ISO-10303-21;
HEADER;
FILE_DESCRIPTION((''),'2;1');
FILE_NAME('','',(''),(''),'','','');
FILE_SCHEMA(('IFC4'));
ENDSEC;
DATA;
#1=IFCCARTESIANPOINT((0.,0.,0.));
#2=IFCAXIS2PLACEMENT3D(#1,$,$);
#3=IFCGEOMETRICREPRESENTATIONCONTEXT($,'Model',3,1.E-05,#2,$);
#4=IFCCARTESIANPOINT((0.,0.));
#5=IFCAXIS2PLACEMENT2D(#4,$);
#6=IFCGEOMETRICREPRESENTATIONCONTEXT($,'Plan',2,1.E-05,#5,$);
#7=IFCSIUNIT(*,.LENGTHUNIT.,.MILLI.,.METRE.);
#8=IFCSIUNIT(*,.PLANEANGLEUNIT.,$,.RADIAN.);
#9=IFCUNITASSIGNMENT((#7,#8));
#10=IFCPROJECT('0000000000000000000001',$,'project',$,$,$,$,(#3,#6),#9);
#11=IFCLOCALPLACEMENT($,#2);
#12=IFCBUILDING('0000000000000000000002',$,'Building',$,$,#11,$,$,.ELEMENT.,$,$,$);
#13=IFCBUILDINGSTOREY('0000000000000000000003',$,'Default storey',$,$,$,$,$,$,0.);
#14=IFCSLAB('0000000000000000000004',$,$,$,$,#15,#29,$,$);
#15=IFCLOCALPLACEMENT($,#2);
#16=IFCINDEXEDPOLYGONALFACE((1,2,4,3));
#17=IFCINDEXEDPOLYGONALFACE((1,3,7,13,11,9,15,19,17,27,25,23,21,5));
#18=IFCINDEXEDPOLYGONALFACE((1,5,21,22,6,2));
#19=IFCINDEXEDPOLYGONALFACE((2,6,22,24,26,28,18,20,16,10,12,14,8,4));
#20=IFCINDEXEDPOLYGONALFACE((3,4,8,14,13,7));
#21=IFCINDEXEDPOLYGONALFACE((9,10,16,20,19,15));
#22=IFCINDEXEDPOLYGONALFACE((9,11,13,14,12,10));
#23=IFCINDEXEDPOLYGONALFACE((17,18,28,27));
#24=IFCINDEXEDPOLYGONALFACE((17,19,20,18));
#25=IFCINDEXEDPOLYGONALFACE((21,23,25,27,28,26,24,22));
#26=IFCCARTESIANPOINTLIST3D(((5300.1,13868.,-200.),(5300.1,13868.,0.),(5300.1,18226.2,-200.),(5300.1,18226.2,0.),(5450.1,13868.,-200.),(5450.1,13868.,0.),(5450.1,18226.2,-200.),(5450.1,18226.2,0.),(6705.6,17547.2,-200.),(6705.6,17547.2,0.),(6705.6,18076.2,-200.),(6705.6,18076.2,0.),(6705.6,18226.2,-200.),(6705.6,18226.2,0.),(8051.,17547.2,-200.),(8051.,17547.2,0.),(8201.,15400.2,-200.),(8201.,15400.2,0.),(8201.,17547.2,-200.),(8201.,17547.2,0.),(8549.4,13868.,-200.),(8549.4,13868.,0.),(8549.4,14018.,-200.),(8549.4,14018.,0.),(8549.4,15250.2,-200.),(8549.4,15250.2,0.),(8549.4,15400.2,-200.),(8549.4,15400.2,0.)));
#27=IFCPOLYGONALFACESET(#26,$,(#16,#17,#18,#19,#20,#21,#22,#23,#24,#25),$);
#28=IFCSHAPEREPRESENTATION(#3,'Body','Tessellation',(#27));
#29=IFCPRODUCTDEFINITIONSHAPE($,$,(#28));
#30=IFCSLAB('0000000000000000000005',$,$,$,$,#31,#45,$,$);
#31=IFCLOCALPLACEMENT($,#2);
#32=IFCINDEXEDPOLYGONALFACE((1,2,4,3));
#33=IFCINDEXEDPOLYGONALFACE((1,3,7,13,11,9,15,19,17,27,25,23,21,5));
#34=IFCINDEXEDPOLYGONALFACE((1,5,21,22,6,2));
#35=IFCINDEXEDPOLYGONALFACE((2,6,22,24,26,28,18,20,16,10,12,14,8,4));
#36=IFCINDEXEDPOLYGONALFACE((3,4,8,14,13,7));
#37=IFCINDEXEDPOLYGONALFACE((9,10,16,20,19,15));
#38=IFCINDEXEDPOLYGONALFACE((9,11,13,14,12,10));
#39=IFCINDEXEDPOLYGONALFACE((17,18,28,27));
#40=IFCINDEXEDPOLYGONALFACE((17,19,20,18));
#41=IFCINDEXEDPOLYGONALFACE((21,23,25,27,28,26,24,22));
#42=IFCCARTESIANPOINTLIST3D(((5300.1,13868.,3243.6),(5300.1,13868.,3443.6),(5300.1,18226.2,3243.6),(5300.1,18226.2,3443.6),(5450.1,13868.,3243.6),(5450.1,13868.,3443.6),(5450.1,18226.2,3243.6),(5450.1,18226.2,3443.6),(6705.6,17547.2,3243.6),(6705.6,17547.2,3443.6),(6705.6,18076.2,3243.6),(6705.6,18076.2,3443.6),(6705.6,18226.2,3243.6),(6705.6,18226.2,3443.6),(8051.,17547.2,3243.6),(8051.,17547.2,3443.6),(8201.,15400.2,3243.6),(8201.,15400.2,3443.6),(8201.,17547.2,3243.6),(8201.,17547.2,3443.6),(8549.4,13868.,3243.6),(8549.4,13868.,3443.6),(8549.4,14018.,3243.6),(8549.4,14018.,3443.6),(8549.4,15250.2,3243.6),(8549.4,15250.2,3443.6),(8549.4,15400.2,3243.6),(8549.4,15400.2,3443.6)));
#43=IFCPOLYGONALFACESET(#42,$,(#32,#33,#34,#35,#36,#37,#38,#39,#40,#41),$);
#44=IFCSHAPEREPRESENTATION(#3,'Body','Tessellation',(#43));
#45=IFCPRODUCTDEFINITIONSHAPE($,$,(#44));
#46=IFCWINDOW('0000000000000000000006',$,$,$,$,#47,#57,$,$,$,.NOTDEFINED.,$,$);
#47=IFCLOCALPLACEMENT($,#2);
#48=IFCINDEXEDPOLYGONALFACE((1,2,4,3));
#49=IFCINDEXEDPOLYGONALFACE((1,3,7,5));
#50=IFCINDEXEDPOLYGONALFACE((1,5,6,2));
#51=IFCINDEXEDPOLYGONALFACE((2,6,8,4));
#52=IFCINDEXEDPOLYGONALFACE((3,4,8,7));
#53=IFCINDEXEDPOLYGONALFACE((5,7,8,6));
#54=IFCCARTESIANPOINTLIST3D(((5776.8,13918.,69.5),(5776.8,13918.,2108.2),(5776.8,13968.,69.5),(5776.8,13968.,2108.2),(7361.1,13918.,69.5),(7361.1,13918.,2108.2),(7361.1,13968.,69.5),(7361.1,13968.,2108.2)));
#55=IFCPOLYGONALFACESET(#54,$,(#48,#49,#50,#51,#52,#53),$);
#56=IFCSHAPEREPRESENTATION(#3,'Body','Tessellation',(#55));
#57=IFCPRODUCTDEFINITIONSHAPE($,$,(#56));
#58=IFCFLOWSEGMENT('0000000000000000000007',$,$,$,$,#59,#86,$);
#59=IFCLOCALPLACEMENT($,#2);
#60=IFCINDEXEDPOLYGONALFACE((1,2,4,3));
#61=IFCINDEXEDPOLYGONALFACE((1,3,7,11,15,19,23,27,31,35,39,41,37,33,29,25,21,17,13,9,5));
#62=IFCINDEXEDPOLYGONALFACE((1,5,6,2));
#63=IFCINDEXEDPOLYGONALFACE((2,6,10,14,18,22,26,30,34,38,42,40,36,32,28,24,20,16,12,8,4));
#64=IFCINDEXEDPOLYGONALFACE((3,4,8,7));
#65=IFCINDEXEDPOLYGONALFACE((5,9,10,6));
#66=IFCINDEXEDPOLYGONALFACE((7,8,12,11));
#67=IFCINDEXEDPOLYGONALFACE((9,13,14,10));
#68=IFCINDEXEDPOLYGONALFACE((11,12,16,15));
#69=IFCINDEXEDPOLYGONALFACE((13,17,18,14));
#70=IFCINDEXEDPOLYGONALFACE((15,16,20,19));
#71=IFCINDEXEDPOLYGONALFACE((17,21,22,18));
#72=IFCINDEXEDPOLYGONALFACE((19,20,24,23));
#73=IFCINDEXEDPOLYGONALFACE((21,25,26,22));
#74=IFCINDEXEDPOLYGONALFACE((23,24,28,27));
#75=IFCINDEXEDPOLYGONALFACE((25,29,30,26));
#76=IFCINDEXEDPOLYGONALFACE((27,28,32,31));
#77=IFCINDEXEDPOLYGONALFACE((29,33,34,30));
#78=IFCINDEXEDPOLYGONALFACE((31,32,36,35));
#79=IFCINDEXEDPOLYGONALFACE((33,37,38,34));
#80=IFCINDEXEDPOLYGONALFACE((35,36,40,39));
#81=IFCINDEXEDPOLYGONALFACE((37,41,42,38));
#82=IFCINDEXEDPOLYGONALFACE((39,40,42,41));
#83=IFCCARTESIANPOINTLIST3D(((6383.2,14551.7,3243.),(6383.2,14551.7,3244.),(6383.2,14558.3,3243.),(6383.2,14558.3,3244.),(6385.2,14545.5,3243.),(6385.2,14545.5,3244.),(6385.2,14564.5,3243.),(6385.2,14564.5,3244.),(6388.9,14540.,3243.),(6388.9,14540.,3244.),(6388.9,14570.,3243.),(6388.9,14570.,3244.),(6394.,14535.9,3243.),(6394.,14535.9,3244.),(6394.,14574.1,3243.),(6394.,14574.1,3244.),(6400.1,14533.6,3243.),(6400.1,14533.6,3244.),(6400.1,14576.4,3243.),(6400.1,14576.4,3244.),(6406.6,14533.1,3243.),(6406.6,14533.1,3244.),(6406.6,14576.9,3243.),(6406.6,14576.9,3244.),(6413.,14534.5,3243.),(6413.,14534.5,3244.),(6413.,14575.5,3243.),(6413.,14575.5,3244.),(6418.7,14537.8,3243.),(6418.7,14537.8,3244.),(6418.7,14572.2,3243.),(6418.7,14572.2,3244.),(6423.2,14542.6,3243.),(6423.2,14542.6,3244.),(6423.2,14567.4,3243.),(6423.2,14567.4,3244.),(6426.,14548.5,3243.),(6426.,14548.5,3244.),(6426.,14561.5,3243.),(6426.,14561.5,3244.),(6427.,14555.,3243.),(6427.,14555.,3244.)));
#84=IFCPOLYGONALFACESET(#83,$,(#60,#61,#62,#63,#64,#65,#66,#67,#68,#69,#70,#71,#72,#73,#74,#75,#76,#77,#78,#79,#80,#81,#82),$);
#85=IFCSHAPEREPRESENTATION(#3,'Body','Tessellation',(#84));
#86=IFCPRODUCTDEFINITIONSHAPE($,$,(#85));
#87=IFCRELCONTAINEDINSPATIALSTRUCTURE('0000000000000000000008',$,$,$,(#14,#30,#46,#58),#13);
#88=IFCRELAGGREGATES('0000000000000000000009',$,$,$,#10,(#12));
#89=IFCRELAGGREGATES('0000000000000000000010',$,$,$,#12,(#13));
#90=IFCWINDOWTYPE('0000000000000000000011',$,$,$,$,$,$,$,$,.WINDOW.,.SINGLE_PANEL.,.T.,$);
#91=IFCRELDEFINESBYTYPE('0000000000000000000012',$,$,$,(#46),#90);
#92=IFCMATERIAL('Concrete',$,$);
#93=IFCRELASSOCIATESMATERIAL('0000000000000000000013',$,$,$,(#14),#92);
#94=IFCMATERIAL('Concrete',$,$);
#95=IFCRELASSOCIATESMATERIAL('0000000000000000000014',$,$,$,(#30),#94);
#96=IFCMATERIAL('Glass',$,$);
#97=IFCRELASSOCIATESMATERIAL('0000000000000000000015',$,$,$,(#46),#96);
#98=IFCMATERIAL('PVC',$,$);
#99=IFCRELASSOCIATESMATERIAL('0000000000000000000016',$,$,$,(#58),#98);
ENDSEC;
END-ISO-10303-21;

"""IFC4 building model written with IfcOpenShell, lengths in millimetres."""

from ifc_helpers import new_model, si_unit, frame, origin, origin_2d, place, context, project, spatial, polyline, rectangle, circle, outline, extrude, material, type_object, element, save


model = new_model("IFC4")

# Units and contexts
model_context = context("Model", 3, precision=1e-05, world=origin())
plan_context = context("Plan", 2, precision=1e-05, world=origin_2d())
ifc_project = project(units=[si_unit("LENGTHUNIT", "METRE", prefix="MILLI"), si_unit("PLANEANGLEUNIT", "RADIAN")], contexts=[model_context, plan_context])

# Building, storey
placement = place(None, origin())
building = spatial("IfcBuilding", under=ifc_project, at=placement, Name="Building", CompositionType="ELEMENT")
storey = spatial("IfcBuildingStorey", under=building, Name="Default storey", Elevation=0.0)

# Slabs
ifc_material_1 = material(Name="Concrete")
element("IfcSlab", 1, at=placement, inside=storey, material=ifc_material_1, context=model_context, shape_type="SweptSolid", body=[
    extrude(outline(polyline([(8201.0, 15400.2), (8201.0, 17547.2), (8051.0, 17547.2), (6705.6, 17547.2), (6705.6, 18076.2), (6705.6, 18226.2), (5450.1, 18226.2), (5300.1, 18226.2), (5300.1, 13868.0), (5450.1, 13868.0), (8549.4, 13868.0), (8549.4, 14018.0), (8549.4, 15250.2), (8549.4, 15400.2), (8201.0, 15400.2)])), frame((0.0, 0.0, -200.0), z_axis=(0.0, 0.0, 1000.0), x_axis=(1000.0, 0.0, 0.0)), (0.0, 0.0, 1.0), 200.0),
])
ifc_material_2 = material(Name="Concrete")
element("IfcSlab", 2, at=placement, inside=storey, material=ifc_material_2, context=model_context, shape_type="SweptSolid", body=[
    extrude(outline(polyline([(8201.0, 15400.2), (8201.0, 17547.2), (8051.0, 17547.2), (6705.6, 17547.2), (6705.6, 18076.2), (6705.6, 18226.2), (5450.1, 18226.2), (5300.1, 18226.2), (5300.1, 13868.0), (5450.1, 13868.0), (8549.4, 13868.0), (8549.4, 14018.0), (8549.4, 15250.2), (8549.4, 15400.2), (8201.0, 15400.2)])), frame((0.0, 0.0, 3243.6), z_axis=(0.0, 0.0, 1000.0), x_axis=(1000.0, 0.0, 0.0)), (0.0, 0.0, 1.0), 200.0),
])

# Window
ifc_material_3 = material(Name="Glass")
window_type = type_object("IfcWindowType", ParameterTakesPrecedence=True, PartitioningType="SINGLE_PANEL", PredefinedType="WINDOW")
element("IfcWindow", 3, at=placement, inside=storey, type_object=window_type, material=ifc_material_3, PredefinedType="NOTDEFINED", context=model_context, shape_type="CSG", body=[
    extrude(rectangle(XDim=1584.2, YDim=50.0, at=origin_2d()), frame((6568.9, 13943.0, 69.5), z_axis=(0.0, 0.0, 1000.0), x_axis=(1584.249973, 0.0, 0.0)), (0.0, 0.0, 1.0), 2038.7),
])

# Flow segment
ifc_material_4 = material(Name="PVC")
element("IfcFlowSegment", 4, at=placement, inside=storey, material=ifc_material_4, context=model_context, shape_type="SweptSolid", body=[
    extrude(circle(Radius=22.0, at=origin_2d()), frame((6405.0, 14555.0, 3243.0), z_axis=(0.0, 0.0, 1.0), x_axis=(1000.0, 0.0, 0.0)), (0.0, 0.0, 1.0), 1.0),
])

save(model, "model.ifc")
